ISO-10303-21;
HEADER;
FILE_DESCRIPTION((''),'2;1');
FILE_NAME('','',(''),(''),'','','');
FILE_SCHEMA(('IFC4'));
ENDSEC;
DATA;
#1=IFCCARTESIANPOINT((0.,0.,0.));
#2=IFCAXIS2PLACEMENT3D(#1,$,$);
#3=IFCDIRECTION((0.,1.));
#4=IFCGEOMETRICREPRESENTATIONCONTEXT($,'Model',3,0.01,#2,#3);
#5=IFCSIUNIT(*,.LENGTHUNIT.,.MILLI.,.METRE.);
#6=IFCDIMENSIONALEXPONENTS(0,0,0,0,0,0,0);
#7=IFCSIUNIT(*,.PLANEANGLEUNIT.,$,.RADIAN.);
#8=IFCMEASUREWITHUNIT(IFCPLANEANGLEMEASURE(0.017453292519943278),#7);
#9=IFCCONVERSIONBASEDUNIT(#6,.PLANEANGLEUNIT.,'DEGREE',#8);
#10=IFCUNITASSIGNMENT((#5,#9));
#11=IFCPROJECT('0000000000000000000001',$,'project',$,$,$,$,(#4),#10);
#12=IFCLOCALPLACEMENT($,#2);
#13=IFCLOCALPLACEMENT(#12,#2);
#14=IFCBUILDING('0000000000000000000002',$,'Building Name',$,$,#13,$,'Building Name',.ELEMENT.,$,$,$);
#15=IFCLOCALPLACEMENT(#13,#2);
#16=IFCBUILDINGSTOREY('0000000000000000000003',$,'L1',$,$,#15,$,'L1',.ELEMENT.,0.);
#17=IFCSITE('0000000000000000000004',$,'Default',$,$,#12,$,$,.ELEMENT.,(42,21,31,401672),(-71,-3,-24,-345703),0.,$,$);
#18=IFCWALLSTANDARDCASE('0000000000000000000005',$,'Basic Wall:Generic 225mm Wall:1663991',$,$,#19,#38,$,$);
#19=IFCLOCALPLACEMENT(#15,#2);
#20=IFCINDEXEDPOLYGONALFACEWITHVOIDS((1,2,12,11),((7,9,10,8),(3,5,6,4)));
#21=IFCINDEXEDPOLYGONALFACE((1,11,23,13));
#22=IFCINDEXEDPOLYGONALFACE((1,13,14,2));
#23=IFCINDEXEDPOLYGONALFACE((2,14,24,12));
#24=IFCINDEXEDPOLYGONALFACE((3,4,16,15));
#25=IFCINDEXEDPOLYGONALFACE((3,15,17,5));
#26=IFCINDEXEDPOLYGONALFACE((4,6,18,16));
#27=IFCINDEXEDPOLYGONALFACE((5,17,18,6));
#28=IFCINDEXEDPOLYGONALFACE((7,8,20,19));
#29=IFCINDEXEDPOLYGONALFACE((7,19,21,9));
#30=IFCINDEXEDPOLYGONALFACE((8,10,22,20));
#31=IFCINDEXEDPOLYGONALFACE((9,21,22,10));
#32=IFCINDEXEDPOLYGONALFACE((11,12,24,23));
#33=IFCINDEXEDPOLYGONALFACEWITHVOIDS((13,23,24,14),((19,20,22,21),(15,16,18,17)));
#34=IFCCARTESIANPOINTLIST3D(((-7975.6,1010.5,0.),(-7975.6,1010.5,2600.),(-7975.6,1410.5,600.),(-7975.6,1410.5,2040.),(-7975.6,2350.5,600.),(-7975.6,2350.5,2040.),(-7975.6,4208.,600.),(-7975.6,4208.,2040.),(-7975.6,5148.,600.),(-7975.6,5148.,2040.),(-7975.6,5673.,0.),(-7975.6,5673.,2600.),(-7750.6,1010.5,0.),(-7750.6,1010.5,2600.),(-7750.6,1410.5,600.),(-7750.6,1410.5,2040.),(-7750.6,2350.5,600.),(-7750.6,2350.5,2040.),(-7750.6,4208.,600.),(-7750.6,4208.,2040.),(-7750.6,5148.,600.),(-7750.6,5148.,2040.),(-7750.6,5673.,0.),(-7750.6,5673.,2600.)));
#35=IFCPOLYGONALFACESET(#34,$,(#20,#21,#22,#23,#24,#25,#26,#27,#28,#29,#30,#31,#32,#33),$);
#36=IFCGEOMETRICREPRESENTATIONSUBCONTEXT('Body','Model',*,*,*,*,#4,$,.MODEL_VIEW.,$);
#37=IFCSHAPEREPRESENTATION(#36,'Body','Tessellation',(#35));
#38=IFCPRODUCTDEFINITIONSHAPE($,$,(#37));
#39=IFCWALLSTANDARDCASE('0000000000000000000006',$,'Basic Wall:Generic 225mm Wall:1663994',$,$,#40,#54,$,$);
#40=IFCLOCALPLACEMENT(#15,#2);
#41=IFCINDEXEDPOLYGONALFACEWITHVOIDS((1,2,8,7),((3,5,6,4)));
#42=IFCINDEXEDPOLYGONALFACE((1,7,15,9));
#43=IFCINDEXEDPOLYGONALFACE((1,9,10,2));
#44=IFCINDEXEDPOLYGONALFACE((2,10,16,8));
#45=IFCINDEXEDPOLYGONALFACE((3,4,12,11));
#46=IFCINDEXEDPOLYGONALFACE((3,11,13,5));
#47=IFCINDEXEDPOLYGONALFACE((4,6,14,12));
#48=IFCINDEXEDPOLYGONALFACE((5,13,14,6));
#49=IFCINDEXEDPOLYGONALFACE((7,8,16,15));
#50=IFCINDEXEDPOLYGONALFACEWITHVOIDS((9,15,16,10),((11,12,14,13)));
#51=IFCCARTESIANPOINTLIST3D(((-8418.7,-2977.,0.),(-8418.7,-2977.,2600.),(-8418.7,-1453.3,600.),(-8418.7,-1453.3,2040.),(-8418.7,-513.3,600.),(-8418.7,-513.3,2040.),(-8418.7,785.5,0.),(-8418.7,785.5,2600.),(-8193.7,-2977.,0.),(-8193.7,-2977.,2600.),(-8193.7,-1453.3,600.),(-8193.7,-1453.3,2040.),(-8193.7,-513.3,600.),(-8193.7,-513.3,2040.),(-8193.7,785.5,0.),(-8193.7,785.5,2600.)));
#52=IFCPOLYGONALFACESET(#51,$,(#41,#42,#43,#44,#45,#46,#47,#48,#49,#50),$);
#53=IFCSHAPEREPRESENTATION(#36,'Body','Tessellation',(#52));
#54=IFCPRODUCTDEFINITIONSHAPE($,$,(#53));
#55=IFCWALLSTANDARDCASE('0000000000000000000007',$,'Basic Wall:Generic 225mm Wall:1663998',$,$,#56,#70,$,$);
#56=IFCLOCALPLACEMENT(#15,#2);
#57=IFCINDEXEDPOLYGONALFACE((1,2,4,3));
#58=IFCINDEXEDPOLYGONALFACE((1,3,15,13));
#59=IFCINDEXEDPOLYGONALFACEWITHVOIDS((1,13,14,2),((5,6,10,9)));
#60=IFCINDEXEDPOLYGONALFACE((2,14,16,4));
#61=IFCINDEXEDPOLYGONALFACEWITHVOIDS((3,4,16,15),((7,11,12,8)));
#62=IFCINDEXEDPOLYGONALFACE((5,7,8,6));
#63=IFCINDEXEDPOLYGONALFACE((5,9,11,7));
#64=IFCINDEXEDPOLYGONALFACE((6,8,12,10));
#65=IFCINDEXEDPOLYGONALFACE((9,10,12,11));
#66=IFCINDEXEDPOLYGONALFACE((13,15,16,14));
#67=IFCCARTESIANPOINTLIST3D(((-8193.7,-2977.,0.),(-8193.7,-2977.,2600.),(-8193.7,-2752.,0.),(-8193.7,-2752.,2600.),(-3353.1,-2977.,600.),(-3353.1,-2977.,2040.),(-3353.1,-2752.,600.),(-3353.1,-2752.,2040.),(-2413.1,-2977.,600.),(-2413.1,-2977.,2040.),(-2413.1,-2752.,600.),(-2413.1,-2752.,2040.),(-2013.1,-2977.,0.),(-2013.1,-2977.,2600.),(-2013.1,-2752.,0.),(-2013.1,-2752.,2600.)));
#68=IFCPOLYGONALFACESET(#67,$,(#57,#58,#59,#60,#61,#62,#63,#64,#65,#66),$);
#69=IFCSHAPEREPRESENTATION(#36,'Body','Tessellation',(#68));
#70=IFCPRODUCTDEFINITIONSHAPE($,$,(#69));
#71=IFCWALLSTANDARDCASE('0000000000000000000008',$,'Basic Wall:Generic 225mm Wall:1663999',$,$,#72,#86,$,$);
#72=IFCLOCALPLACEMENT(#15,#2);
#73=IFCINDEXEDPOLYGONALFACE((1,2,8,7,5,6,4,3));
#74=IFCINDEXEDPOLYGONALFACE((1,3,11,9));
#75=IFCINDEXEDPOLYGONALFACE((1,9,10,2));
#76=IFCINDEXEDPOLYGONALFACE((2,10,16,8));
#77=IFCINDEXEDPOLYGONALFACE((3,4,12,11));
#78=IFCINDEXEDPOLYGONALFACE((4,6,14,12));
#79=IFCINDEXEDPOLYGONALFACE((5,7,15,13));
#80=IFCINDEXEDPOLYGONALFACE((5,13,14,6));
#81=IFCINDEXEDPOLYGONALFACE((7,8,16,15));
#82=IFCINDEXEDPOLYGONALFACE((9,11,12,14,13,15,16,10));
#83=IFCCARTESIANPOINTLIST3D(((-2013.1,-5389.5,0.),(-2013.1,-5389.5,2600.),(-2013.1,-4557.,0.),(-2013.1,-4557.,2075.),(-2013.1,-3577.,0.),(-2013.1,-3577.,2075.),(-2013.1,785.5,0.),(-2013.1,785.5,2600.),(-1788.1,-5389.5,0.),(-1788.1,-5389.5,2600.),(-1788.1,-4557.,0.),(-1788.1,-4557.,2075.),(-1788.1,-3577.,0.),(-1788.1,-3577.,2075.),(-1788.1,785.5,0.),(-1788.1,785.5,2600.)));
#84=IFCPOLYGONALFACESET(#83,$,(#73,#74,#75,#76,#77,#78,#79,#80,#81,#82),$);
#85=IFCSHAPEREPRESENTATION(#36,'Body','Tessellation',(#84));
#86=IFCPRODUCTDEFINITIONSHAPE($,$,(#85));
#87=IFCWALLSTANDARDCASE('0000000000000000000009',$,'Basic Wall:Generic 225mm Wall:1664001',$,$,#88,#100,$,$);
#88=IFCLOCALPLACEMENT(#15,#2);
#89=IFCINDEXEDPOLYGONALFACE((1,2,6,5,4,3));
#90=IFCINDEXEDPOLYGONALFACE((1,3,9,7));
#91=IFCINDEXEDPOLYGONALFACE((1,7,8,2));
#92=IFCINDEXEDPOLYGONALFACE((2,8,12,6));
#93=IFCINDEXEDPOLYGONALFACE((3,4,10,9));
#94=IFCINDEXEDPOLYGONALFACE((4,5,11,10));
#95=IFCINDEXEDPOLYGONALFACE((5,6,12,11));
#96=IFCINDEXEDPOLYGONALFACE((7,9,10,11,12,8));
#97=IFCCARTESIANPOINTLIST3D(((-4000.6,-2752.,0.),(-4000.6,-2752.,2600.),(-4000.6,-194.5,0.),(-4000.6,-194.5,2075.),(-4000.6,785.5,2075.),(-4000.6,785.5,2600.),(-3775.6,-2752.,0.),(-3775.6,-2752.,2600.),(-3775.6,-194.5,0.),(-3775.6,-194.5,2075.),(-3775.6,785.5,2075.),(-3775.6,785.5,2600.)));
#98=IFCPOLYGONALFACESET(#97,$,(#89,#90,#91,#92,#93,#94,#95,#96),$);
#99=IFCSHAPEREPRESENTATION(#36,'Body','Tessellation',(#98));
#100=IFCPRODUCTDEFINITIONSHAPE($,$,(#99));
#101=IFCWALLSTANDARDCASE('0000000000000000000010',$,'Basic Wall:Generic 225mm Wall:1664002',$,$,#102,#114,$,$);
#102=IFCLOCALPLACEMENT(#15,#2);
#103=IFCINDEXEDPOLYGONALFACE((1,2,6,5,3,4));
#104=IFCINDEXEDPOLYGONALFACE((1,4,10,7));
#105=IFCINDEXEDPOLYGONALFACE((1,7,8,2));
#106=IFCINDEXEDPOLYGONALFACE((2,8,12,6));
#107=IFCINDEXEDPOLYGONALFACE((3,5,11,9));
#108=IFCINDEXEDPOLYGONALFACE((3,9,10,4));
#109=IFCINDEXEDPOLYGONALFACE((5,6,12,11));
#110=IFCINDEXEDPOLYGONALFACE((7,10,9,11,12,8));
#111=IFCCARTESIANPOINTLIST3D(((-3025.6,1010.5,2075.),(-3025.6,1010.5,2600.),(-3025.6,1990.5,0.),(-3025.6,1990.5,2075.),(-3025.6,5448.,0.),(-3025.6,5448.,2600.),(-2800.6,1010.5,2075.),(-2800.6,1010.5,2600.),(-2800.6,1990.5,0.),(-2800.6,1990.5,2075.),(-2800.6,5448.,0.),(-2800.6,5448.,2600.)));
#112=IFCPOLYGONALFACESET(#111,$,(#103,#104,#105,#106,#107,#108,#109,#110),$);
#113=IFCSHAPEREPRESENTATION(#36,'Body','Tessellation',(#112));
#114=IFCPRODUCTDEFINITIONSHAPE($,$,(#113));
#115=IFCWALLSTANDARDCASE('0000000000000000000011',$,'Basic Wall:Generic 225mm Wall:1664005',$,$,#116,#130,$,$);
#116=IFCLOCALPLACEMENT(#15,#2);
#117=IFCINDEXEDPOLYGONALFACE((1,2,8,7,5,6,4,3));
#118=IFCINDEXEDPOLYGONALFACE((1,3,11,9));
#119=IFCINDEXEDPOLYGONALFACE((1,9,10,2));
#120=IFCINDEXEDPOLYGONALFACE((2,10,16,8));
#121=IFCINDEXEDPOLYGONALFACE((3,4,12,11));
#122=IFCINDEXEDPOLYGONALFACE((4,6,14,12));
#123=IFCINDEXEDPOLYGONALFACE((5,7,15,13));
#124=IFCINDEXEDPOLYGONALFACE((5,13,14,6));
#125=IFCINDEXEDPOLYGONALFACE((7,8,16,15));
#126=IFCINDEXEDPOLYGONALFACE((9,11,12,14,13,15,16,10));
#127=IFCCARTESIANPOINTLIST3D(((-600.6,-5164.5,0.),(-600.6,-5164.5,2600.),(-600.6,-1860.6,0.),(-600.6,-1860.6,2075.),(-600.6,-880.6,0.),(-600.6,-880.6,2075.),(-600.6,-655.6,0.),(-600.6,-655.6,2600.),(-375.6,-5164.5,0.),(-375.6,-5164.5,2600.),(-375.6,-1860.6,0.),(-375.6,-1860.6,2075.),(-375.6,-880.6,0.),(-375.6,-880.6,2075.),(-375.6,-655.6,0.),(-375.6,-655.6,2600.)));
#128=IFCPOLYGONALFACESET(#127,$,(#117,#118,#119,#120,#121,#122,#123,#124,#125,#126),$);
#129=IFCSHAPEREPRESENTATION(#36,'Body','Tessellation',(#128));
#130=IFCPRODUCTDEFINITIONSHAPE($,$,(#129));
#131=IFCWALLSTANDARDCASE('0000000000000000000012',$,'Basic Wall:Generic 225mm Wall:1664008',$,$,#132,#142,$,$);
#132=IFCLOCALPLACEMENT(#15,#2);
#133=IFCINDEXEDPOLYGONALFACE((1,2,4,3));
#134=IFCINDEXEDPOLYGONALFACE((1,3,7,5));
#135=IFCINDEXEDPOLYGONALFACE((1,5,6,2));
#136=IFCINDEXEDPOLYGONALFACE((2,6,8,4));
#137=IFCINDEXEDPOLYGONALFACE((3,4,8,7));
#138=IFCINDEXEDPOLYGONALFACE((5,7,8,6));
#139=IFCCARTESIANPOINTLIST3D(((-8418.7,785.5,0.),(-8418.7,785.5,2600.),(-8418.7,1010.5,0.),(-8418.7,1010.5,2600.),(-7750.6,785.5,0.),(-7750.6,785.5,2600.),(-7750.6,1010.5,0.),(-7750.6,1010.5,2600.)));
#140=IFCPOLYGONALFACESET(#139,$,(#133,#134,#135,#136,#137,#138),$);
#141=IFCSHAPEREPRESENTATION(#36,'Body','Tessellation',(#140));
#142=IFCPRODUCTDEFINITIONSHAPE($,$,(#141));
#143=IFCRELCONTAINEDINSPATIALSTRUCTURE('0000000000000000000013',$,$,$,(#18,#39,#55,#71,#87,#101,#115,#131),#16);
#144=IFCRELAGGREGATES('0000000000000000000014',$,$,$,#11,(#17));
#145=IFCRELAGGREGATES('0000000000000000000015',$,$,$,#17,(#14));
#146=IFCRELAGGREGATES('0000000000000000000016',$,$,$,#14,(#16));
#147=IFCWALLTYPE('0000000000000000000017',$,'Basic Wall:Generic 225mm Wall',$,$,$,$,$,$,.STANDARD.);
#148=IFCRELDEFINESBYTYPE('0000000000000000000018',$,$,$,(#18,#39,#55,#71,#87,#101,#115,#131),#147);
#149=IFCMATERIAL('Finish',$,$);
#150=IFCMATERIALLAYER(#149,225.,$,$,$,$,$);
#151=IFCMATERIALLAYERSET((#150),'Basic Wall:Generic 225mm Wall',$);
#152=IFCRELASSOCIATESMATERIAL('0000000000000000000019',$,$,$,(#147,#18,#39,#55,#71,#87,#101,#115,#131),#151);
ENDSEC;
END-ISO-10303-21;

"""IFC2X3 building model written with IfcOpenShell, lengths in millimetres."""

from ifc_helpers import new_model, entity, si_unit, converted_unit, direction, frame, frame_2d, origin, place, context, subcontext, project, spatial, rectangle, extrude, material, layer, layer_set, layer_usage, type_object, element, save


model = new_model("IFC2X3")

# Units and contexts
model_context = context("Model", 3, precision=0.01, world=origin(), true_north=direction((0.0, 1.0)))
body_context = subcontext(model_context, "Body", "Model", "MODEL_VIEW")
ifc_project = project(units=[si_unit("LENGTHUNIT", "METRE", prefix="MILLI"), converted_unit("PLANEANGLEUNIT", "DEGREE", entity("IfcPlaneAngleMeasure", 0.017453292519943278), si_unit("PLANEANGLEUNIT", "RADIAN"), dimensions=[0, 0, 0, 0, 0, 0, 0])], contexts=[model_context])

# Site, building, storey
site_placement = place(None, origin())
site = spatial("IfcSite", under=ifc_project, at=site_placement, Name="Default", CompositionType="ELEMENT", RefLatitude=(42, 21, 31, 401672), RefLongitude=(-71, -3, -24, -345703), RefElevation=0.0)
building_placement = place(site_placement, origin())
building = spatial("IfcBuilding", under=site, at=building_placement, Name="Building Name", LongName="Building Name", CompositionType="ELEMENT")
storey_placement = place(building_placement, origin())
storey = spatial("IfcBuildingStorey", under=building, at=storey_placement, Name="L1", LongName="L1", CompositionType="ELEMENT", Elevation=0.0)

# Wall, openings
ifc_material_1 = material(Name="Finish")
ifc_layer_1 = layer(ifc_material_1, 225.0)
ifc_layer_set_1 = layer_set([ifc_layer_1], Name="Basic Wall:Generic 225mm Wall")
ifc_layer_usage_1 = layer_usage(ifc_layer_set_1, "AXIS2", "NEGATIVE", 112.5)
wall_type = type_object("IfcWallType", Name="Basic Wall:Generic 225mm Wall", PredefinedType="STANDARD", material=ifc_layer_set_1)
wall_1_placement = place(storey_placement, frame((-7863.1, 1010.5, 0.0), z_axis=(0.0, 0.0, 1.0), x_axis=(0.0, 1.0, 0.0)))
wall_1 = element("IfcWallStandardCase", 1, at=wall_1_placement, inside=storey, type_object=wall_type, material=ifc_layer_usage_1, Name="Basic Wall:Generic 225mm Wall:1663991", context=body_context, shape_type="SweptSolid", body=[
    extrude(rectangle(XDim=4662.5, YDim=225.0, at=frame_2d((2331.3, 0.0), x_axis=(-1.0, 0.0))), origin(), (0.0, 0.0, 1.0), 2600.0),
])
opening_1_placement = place(wall_1_placement, origin())
element("IfcOpeningElement", 2, at=opening_1_placement, cuts=wall_1, ObjectType="Opening", context=body_context, shape_type="SweptSolid", body=[
    extrude(rectangle(XDim=1440.0, YDim=940.0, at=frame_2d((0.0, 0.0), x_axis=(0.0, 1.0))), frame((3667.5, -112.5, 1320.0), z_axis=(0.0, 1.0, 0.0), x_axis=(1.0, 0.0, 0.0)), (0.0, 0.0, 1.0), 225.0),
])
opening_2_placement = place(wall_1_placement, origin())
element("IfcOpeningElement", 3, at=opening_2_placement, cuts=wall_1, ObjectType="Opening", context=body_context, shape_type="SweptSolid", body=[
    extrude(rectangle(XDim=1440.0, YDim=940.0, at=frame_2d((0.0, 0.0), x_axis=(0.0, 1.0))), frame((870.0, -112.5, 1320.0), z_axis=(0.0, 1.0, 0.0), x_axis=(1.0, 0.0, 0.0)), (0.0, 0.0, 1.0), 225.0),
])

# Walls, openings
ifc_layer_usage_2 = layer_usage(ifc_layer_set_1, "AXIS2", "NEGATIVE", 112.5)
wall_2_placement = place(storey_placement, frame((-8306.2, -2977.0, 0.0), z_axis=(0.0, 0.0, 1.0), x_axis=(0.0, 1.0, 0.0)))
wall_2 = element("IfcWallStandardCase", 4, at=wall_2_placement, inside=storey, type_object=wall_type, material=ifc_layer_usage_2, Name="Basic Wall:Generic 225mm Wall:1663994", context=body_context, shape_type="SweptSolid", body=[
    extrude(rectangle(XDim=3762.5, YDim=225.0, at=frame_2d((1881.2, 0.0), x_axis=(-1.0, 0.0))), origin(), (0.0, 0.0, 1.0), 2600.0),
])
opening_3_placement = place(wall_2_placement, origin())
element("IfcOpeningElement", 5, at=opening_3_placement, cuts=wall_2, ObjectType="Opening", context=body_context, shape_type="SweptSolid", body=[
    extrude(rectangle(XDim=1440.0, YDim=940.0, at=frame_2d((0.0, 0.0), x_axis=(0.0, 1.0))), frame((1993.7, -112.5, 1320.0), z_axis=(0.0, 1.0, 0.0), x_axis=(1.0, 0.0, 0.0)), (0.0, 0.0, 1.0), 225.0),
])
ifc_layer_usage_3 = layer_usage(ifc_layer_set_1, "AXIS2", "NEGATIVE", 112.5)
wall_3_placement = place(storey_placement, frame((-8193.7, -2864.5, 0.0)))
wall_3 = element("IfcWallStandardCase", 6, at=wall_3_placement, inside=storey, type_object=wall_type, material=ifc_layer_usage_3, Name="Basic Wall:Generic 225mm Wall:1663998", context=body_context, shape_type="SweptSolid", body=[
    extrude(rectangle(XDim=6180.6, YDim=225.0, at=frame_2d((3090.3, 0.0), x_axis=(-1.0, 0.0))), origin(), (0.0, 0.0, 1.0), 2600.0),
])
opening_4_placement = place(wall_3_placement, origin())
element("IfcOpeningElement", 7, at=opening_4_placement, cuts=wall_3, ObjectType="Opening", context=body_context, shape_type="SweptSolid", body=[
    extrude(rectangle(XDim=1440.0, YDim=940.0, at=frame_2d((0.0, 0.0), x_axis=(0.0, 1.0))), frame((5310.6, -112.5, 1320.0), z_axis=(0.0, 1.0, 0.0), x_axis=(1.0, 0.0, 0.0)), (0.0, 0.0, 1.0), 225.0),
])
ifc_layer_usage_4 = layer_usage(ifc_layer_set_1, "AXIS2", "NEGATIVE", 112.5)
wall_4_placement = place(storey_placement, frame((-1900.6, -5389.5, 0.0), z_axis=(0.0, 0.0, 1.0), x_axis=(0.0, 1.0, 0.0)))
wall_4 = element("IfcWallStandardCase", 8, at=wall_4_placement, inside=storey, type_object=wall_type, material=ifc_layer_usage_4, Name="Basic Wall:Generic 225mm Wall:1663999", context=body_context, shape_type="SweptSolid", body=[
    extrude(rectangle(XDim=6175.0, YDim=225.0, at=frame_2d((3087.5, 0.0), x_axis=(-1.0, 0.0))), origin(), (0.0, 0.0, 1.0), 2600.0),
])
opening_5_placement = place(wall_4_placement, frame((1812.5, 112.5, 0.0)))
element("IfcOpeningElement", 9, at=opening_5_placement, cuts=wall_4, ObjectType="Opening", context=body_context, shape_type="SweptSolid", body=[
    extrude(rectangle(XDim=980.0, YDim=2075.0, at=frame_2d((1037.5, 490.0), x_axis=(0.0, -1.0))), frame((0.0, 0.0, 0.0), z_axis=(0.0, -1.0, 0.0), x_axis=(0.0, 0.0, 1.0)), (0.0, 0.0, 1.0), 225.0),
])
ifc_layer_usage_5 = layer_usage(ifc_layer_set_1, "AXIS2", "NEGATIVE", 112.5)
wall_5_placement = place(storey_placement, frame((-3888.1, -2752.0, 0.0), z_axis=(0.0, 0.0, 1.0), x_axis=(0.0, 1.0, 0.0)))
wall_5 = element("IfcWallStandardCase", 10, at=wall_5_placement, inside=storey, type_object=wall_type, material=ifc_layer_usage_5, Name="Basic Wall:Generic 225mm Wall:1664001", context=body_context, shape_type="SweptSolid", body=[
    extrude(rectangle(XDim=3537.5, YDim=225.0, at=frame_2d((1768.7, 0.0), x_axis=(-1.0, 0.0))), origin(), (0.0, 0.0, 1.0), 2600.0),
])
opening_6_placement = place(wall_5_placement, frame((2557.5, -112.5, 0.0)))
element("IfcOpeningElement", 11, at=opening_6_placement, cuts=wall_5, ObjectType="Opening", context=body_context, shape_type="SweptSolid", body=[
    extrude(rectangle(XDim=980.0, YDim=2075.0, at=frame_2d((1037.5, 490.0), x_axis=(0.0, -1.0))), frame((0.0, 0.0, 0.0), z_axis=(0.0, 1.0, 0.0), x_axis=(0.0, 0.0, 1.0)), (0.0, 0.0, 1.0), 225.0),
])
ifc_layer_usage_6 = layer_usage(ifc_layer_set_1, "AXIS2", "NEGATIVE", 112.5)
wall_6_placement = place(storey_placement, frame((-2913.1, 1010.5, 0.0), z_axis=(0.0, 0.0, 1.0), x_axis=(0.0, 1.0, 0.0)))
wall_6 = element("IfcWallStandardCase", 12, at=wall_6_placement, inside=storey, type_object=wall_type, material=ifc_layer_usage_6, Name="Basic Wall:Generic 225mm Wall:1664002", context=body_context, shape_type="SweptSolid", body=[
    extrude(rectangle(XDim=4437.5, YDim=225.0, at=frame_2d((2218.8, 0.0), x_axis=(-1.0, 0.0))), origin(), (0.0, 0.0, 1.0), 2600.0),
])
opening_7_placement = place(wall_6_placement, frame((980.0, 112.5, 0.0)))
element("IfcOpeningElement", 13, at=opening_7_placement, cuts=wall_6, ObjectType="Opening", context=body_context, shape_type="SweptSolid", body=[
    extrude(rectangle(XDim=980.0, YDim=2075.0, at=frame_2d((1037.5, 490.0), x_axis=(0.0, -1.0))), frame((0.0, 0.0, 0.0), z_axis=(0.0, -1.0, 0.0), x_axis=(0.0, 0.0, 1.0)), (0.0, 0.0, 1.0), 225.0),
])
ifc_layer_usage_7 = layer_usage(ifc_layer_set_1, "AXIS2", "NEGATIVE", 112.5)
wall_7_placement = place(storey_placement, frame((-488.1, -5164.5, 0.0), z_axis=(0.0, 0.0, 1.0), x_axis=(0.0, 1.0, 0.0)))
wall_7 = element("IfcWallStandardCase", 14, at=wall_7_placement, inside=storey, type_object=wall_type, material=ifc_layer_usage_7, Name="Basic Wall:Generic 225mm Wall:1664005", context=body_context, shape_type="SweptSolid", body=[
    extrude(rectangle(XDim=4508.9, YDim=225.0, at=frame_2d((2254.5, 0.0), x_axis=(1.0, 0.0))), origin(), (0.0, 0.0, 1.0), 2600.0),
])
opening_8_placement = place(wall_7_placement, frame((3303.9, -112.5, 0.0)))
element("IfcOpeningElement", 15, at=opening_8_placement, cuts=wall_7, ObjectType="Opening", context=body_context, shape_type="SweptSolid", body=[
    extrude(rectangle(XDim=980.0, YDim=2075.0, at=frame_2d((1037.5, 490.0), x_axis=(0.0, -1.0))), frame((0.0, 0.0, 0.0), z_axis=(0.0, 1.0, 0.0), x_axis=(0.0, 0.0, 1.0)), (0.0, 0.0, 1.0), 225.0),
])

# Wall
ifc_layer_usage_8 = layer_usage(ifc_layer_set_1, "AXIS2", "NEGATIVE", 112.5)
wall_8_placement = place(storey_placement, frame((-7750.6, 898.0, 0.0), z_axis=(0.0, 0.0, 1.0), x_axis=(-1.0, 0.0, 0.0)))
element("IfcWallStandardCase", 16, at=wall_8_placement, inside=storey, type_object=wall_type, material=ifc_layer_usage_8, Name="Basic Wall:Generic 225mm Wall:1664008", context=body_context, shape_type="SweptSolid", body=[
    extrude(rectangle(XDim=668.1, YDim=225.0, at=frame_2d((334.0, 0.0), x_axis=(-1.0, 0.0))), origin(), (0.0, 0.0, 1.0), 2600.0),
])

save(model, "model.ifc")
